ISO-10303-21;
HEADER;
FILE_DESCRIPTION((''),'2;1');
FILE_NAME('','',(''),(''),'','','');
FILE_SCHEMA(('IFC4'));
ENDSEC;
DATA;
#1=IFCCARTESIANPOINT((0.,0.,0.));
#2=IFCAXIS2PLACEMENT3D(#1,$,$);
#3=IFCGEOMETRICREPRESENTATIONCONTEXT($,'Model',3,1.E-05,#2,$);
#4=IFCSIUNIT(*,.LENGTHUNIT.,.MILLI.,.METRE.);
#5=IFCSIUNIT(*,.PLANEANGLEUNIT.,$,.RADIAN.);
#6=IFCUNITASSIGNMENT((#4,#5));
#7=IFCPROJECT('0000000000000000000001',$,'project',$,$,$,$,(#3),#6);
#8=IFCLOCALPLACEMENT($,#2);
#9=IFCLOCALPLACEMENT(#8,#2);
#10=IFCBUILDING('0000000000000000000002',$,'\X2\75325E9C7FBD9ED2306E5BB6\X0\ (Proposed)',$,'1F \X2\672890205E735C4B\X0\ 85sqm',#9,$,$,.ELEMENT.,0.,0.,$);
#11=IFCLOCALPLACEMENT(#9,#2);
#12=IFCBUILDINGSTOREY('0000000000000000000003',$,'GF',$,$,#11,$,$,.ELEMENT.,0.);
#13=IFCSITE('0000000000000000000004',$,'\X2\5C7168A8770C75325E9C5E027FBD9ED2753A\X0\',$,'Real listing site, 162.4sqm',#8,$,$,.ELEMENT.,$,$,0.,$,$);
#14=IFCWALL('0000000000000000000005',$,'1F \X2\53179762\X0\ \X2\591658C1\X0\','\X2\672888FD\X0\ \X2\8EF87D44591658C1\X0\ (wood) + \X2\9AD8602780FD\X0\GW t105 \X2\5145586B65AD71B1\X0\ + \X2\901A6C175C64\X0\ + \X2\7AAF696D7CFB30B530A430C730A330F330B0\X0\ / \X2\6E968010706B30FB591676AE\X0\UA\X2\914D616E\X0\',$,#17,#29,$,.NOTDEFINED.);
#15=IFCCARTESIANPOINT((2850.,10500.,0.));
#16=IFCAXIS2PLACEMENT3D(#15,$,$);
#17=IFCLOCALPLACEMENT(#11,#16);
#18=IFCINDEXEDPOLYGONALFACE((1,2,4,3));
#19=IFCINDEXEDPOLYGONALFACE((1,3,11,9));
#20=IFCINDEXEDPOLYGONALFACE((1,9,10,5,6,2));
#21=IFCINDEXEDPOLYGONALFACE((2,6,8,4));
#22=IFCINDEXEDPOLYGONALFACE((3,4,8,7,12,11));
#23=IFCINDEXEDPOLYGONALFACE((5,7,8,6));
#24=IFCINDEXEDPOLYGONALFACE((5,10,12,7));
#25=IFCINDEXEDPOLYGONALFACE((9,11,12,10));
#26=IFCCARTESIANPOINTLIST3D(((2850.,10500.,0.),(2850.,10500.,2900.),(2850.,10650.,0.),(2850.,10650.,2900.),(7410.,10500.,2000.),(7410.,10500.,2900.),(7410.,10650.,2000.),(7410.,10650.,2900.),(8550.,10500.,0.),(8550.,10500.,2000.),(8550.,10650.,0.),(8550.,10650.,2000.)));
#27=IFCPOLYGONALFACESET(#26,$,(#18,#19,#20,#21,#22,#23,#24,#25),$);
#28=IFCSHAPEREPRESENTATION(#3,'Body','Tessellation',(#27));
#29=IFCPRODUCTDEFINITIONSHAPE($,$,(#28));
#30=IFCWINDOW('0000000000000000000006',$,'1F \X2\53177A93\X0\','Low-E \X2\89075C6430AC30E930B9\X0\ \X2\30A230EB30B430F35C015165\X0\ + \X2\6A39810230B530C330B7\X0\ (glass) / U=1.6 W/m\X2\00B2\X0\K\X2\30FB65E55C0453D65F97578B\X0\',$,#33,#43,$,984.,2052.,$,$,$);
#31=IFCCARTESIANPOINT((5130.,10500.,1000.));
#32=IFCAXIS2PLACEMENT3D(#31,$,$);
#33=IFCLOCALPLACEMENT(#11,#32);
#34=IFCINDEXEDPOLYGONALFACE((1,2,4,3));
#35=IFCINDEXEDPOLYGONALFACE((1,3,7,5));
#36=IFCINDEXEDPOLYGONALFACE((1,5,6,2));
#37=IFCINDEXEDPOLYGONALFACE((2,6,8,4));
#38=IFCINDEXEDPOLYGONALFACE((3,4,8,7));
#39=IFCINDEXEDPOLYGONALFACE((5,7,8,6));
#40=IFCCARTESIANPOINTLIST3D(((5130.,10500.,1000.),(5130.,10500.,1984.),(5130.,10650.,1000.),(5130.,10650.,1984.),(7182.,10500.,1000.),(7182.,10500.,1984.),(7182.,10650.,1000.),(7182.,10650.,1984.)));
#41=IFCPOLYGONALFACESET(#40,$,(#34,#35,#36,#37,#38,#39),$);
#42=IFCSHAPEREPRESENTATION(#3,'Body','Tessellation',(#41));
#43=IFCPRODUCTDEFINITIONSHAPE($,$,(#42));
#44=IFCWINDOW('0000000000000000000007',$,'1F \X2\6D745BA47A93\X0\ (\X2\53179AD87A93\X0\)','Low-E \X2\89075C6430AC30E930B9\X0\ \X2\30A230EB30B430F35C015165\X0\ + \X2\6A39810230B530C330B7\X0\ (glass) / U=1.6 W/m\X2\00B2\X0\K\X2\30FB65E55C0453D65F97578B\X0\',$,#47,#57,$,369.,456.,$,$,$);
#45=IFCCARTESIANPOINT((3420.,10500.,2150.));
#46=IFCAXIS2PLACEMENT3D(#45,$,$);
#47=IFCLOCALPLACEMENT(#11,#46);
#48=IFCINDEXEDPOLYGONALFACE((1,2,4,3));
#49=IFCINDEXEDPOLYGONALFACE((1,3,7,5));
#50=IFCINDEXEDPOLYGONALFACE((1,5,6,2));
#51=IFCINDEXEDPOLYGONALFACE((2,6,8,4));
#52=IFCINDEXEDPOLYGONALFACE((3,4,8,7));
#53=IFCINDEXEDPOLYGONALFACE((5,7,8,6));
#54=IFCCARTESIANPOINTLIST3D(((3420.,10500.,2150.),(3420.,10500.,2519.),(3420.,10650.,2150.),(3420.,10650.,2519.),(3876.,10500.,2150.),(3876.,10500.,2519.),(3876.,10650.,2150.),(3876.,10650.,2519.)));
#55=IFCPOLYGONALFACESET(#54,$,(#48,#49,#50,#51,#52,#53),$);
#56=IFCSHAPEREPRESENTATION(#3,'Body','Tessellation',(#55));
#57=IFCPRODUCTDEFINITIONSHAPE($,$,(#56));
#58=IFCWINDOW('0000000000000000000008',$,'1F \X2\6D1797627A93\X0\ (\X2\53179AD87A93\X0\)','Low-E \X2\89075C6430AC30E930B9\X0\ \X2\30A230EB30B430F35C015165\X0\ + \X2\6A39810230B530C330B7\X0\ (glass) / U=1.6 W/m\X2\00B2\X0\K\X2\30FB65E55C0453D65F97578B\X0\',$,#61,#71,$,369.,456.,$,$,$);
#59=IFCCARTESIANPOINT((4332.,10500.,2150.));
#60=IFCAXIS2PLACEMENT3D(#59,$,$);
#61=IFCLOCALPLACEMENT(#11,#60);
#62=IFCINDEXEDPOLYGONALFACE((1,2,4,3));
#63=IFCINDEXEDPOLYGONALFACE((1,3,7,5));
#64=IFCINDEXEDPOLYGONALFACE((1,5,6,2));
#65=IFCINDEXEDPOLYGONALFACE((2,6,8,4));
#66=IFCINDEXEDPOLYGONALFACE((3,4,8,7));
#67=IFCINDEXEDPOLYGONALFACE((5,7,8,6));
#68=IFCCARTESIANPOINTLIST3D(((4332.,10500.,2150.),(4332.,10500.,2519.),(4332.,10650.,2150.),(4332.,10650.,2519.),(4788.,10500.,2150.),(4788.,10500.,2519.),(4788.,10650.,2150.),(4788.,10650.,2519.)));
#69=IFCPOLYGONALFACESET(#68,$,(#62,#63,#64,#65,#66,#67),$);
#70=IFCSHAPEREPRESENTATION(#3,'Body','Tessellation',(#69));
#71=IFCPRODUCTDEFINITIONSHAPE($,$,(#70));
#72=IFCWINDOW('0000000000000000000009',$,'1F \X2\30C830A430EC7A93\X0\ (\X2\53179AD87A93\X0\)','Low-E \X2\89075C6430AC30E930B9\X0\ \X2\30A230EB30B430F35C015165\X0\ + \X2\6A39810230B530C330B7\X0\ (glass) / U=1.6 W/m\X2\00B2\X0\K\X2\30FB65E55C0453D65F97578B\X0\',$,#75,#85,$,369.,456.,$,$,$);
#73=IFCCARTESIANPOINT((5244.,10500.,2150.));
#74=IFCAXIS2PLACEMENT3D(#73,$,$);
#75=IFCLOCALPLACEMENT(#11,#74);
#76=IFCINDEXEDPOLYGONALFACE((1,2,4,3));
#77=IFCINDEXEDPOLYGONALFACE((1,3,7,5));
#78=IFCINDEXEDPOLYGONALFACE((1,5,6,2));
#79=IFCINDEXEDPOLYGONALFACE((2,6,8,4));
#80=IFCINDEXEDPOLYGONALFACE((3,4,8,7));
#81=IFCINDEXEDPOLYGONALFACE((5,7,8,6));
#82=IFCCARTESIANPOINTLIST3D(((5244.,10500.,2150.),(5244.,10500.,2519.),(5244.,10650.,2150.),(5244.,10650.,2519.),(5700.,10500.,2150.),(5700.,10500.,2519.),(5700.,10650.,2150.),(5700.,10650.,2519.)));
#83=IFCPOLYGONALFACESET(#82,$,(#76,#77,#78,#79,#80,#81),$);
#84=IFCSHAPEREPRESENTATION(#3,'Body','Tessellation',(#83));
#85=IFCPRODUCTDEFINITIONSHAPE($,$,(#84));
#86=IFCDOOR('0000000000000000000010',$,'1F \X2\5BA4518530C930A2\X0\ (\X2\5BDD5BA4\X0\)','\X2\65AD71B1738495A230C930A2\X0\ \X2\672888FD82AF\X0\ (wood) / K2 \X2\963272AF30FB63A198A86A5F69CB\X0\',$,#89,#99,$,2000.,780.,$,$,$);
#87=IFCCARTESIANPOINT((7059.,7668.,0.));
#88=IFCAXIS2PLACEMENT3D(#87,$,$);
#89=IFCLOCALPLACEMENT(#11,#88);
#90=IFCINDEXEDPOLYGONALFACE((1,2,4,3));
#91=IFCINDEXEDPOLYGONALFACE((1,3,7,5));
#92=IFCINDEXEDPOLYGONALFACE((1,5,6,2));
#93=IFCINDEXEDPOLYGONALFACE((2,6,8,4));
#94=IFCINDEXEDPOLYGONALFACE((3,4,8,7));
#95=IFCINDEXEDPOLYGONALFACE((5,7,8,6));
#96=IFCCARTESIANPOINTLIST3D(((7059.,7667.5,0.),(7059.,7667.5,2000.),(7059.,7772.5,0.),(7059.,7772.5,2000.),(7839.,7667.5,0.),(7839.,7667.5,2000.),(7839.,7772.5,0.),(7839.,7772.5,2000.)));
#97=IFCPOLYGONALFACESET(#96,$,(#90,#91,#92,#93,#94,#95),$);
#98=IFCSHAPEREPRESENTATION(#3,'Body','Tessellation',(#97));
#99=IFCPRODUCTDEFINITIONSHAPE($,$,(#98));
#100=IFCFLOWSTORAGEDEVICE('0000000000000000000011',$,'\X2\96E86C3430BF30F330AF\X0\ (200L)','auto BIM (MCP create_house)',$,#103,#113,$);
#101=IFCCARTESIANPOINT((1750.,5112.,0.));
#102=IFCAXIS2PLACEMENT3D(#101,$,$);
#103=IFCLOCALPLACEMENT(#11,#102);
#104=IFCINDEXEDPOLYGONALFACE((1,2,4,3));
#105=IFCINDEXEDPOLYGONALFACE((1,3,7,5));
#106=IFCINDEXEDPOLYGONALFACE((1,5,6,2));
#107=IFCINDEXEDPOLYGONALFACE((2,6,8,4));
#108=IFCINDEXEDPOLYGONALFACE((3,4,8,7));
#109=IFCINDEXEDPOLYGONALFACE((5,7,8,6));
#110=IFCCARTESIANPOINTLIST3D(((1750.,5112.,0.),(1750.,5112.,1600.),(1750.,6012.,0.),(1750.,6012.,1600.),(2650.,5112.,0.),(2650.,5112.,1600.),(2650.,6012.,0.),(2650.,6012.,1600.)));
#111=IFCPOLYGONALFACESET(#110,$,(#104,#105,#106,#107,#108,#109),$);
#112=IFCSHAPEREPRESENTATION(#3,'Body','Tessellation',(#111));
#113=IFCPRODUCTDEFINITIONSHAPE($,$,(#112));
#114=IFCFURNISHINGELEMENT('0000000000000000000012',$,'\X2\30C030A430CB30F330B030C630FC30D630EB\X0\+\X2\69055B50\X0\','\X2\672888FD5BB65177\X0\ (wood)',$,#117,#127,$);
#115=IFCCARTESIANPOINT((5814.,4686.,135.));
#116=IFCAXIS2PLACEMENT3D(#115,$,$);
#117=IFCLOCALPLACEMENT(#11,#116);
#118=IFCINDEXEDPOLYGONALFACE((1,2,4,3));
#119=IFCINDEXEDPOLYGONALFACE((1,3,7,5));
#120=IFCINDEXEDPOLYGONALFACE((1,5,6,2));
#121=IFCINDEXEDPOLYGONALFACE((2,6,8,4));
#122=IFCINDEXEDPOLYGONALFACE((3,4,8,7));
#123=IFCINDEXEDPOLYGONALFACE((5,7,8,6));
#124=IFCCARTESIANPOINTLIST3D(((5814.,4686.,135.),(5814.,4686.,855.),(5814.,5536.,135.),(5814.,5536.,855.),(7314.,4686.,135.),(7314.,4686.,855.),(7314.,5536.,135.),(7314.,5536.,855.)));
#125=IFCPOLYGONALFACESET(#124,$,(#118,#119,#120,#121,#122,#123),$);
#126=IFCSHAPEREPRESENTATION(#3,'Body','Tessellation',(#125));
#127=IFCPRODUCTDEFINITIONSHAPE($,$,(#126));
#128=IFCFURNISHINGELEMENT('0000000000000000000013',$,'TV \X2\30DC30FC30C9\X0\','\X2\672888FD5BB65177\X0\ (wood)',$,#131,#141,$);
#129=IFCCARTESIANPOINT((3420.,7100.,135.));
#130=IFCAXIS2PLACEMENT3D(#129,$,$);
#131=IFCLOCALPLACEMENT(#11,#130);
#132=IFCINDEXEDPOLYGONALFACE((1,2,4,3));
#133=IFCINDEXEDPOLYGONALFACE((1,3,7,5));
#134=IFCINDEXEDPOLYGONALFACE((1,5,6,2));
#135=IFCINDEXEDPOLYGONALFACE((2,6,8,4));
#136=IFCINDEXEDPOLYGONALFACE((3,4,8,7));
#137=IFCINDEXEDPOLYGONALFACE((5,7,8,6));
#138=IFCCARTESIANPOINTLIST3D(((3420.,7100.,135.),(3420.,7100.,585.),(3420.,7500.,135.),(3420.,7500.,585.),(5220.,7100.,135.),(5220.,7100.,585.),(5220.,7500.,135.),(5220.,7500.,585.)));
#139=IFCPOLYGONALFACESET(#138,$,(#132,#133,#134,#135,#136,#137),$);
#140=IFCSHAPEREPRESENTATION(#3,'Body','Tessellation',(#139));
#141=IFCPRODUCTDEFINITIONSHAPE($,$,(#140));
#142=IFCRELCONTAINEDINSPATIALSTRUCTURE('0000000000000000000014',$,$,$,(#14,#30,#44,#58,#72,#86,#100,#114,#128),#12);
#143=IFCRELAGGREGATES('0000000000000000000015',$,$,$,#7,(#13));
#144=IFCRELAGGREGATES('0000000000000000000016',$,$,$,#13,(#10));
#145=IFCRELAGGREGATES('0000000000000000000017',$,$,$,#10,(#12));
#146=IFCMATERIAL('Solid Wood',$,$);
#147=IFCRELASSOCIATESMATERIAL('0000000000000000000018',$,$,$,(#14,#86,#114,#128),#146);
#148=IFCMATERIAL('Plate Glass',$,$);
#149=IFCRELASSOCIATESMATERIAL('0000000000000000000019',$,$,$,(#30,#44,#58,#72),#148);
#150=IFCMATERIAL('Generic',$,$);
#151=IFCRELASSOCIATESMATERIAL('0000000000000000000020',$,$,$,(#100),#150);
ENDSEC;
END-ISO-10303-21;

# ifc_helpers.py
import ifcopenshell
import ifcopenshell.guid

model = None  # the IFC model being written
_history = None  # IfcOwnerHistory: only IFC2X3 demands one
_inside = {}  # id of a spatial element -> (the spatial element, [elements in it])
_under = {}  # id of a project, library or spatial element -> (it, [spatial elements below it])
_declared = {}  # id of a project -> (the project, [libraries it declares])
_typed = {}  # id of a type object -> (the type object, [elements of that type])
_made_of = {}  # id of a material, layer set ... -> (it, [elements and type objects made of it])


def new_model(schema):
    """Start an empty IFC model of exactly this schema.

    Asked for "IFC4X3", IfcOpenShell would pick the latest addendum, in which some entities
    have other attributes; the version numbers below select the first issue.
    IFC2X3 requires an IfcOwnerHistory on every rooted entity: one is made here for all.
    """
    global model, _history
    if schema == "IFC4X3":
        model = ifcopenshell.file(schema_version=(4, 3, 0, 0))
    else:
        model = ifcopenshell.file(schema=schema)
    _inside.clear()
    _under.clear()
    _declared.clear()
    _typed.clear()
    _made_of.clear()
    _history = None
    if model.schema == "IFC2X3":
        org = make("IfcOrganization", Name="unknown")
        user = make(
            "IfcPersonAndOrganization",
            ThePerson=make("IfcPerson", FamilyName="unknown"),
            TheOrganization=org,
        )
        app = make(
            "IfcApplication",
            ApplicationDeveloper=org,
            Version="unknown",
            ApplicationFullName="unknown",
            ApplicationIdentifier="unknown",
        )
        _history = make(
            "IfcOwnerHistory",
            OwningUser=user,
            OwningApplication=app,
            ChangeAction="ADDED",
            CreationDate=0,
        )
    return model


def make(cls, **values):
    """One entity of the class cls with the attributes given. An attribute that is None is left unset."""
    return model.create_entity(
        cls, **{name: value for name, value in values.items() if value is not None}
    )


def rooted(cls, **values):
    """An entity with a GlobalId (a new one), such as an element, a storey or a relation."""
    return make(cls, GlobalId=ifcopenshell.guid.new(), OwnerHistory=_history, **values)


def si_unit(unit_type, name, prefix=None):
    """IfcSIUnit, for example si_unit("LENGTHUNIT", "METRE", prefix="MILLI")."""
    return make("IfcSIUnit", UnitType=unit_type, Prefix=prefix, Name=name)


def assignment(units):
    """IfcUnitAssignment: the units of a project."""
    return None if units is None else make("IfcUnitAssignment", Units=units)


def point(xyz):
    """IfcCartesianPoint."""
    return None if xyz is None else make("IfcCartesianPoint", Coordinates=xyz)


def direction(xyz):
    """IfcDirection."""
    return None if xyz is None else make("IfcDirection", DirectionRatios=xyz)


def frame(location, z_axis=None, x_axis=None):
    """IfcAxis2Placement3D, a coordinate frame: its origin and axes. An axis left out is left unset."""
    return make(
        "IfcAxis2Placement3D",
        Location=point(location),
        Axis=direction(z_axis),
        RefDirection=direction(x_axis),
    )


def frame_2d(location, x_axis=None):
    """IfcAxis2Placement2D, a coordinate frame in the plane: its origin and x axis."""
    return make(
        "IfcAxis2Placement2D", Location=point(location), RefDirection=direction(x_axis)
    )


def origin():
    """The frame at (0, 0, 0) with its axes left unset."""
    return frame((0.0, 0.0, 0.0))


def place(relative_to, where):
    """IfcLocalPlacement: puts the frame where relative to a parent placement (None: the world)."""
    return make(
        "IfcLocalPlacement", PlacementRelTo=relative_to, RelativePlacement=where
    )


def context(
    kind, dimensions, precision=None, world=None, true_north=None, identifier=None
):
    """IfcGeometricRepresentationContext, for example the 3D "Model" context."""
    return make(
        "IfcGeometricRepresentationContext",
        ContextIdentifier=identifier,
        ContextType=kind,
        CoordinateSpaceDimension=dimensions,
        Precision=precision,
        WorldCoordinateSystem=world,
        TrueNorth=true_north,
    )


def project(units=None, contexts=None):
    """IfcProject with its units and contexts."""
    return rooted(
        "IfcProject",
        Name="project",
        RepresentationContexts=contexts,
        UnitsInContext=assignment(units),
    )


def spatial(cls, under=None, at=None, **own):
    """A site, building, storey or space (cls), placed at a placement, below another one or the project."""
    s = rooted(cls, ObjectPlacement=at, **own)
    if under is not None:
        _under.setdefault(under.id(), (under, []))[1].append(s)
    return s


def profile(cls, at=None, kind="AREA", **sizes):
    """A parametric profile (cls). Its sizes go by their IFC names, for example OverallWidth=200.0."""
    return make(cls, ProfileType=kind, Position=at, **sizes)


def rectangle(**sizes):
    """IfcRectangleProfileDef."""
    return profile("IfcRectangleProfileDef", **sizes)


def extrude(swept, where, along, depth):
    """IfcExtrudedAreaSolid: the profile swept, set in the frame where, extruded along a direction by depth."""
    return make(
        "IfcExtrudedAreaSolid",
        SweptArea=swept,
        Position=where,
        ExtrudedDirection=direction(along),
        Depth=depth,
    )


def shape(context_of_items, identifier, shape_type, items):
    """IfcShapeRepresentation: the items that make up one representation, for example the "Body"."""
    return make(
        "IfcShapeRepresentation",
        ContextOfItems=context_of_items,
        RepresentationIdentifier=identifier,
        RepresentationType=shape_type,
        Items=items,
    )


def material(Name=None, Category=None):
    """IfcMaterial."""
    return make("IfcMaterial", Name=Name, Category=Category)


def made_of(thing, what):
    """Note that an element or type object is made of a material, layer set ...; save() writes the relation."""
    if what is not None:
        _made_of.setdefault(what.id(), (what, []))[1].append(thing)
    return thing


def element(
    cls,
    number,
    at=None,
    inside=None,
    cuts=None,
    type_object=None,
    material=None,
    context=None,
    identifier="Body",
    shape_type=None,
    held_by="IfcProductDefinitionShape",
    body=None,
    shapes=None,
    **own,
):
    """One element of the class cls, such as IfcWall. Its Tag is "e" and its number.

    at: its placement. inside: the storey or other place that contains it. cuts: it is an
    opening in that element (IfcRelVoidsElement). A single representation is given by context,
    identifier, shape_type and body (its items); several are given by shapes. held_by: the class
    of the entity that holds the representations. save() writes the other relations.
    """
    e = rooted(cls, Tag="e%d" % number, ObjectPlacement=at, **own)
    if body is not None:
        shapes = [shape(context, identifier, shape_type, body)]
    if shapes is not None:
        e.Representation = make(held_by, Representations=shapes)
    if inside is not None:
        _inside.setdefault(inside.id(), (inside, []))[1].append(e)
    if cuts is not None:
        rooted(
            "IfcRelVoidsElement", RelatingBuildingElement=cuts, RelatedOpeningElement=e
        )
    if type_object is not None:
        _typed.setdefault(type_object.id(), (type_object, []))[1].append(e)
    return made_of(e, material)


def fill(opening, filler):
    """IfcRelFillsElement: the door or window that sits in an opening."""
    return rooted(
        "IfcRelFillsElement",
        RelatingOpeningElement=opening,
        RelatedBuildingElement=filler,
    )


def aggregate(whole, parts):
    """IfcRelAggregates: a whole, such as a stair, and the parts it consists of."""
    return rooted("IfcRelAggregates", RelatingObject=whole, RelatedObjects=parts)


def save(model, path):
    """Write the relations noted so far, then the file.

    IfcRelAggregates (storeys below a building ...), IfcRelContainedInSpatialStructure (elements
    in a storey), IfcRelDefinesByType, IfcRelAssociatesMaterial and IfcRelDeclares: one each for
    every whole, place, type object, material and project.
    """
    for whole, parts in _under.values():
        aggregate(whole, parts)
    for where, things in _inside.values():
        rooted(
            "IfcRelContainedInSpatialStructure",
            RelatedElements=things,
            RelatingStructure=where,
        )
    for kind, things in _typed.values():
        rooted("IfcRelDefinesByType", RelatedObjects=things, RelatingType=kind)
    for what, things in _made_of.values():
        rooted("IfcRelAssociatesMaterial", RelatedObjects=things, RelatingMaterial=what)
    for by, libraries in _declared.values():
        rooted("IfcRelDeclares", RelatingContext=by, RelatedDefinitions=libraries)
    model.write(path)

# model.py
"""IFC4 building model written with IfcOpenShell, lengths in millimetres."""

from ifc_helpers import new_model, si_unit, frame, frame_2d, origin, place, context, project, spatial, rectangle, extrude, material, element, fill, save


model = new_model("IFC4")

# Units and contexts
model_context = context("Model", 3, precision=1e-05, world=origin())
ifc_project = project(units=[si_unit("LENGTHUNIT", "METRE", prefix="MILLI"), si_unit("PLANEANGLEUNIT", "RADIAN")], contexts=[model_context])

# Site, building, storey
site_placement = place(None, origin())
site = spatial("IfcSite", under=ifc_project, at=site_placement, Name="山梨県甲府市羽黒町", ObjectType="Real listing site, 162.4sqm", CompositionType="ELEMENT", RefElevation=0.0)
building_placement = place(site_placement, origin())
building = spatial("IfcBuilding", under=site, at=building_placement, Name="甲府羽黒の家 (Proposed)", ObjectType="1F 木造平屋 85sqm", CompositionType="ELEMENT", ElevationOfRefHeight=0.0, ElevationOfTerrain=0.0)
storey_placement = place(building_placement, origin())
storey = spatial("IfcBuildingStorey", under=building, at=storey_placement, Name="GF", CompositionType="ELEMENT", Elevation=0.0)

# Wall, openings, windows
ifc_material_1 = material(Name="Solid Wood")
wall_1_placement = place(storey_placement, frame((2850.0, 10500.0, 0.0)))
wall_1 = element("IfcWall", 1, at=wall_1_placement, inside=storey, material=ifc_material_1, Name="1F 北面 外壁", Description="木製 軸組外壁 (wood) + 高性能GW t105 充填断熱 + 通気層 + 窯業系サイディング / 準耐火・外皮UA配慮", PredefinedType="NOTDEFINED", context=model_context, shape_type="SweptSolid", body=[
    extrude(rectangle(XDim=5700.0, YDim=150.0, at=frame_2d((2850.0, 75.0))), frame((2850.0, 10500.0, 0.0)), (0.0, 0.0, 1.0), 2900.0),
])
opening_1_placement = place(storey_placement, frame((5130.0, 10500.0, 1000.0)))
opening_1 = element("IfcOpeningElement", 2, at=opening_1_placement, cuts=wall_1, PredefinedType="NOTDEFINED", context=model_context, shape_type="SweptSolid", body=[
    extrude(rectangle(XDim=2052.0, YDim=150.0, at=frame_2d((1026.0, 75.0))), frame((5130.0, 10500.0, 1000.0)), (0.0, 0.0, 1.0), 984.0),
])
opening_2_placement = place(storey_placement, frame((3420.0, 10500.0, 2150.0)))
opening_2 = element("IfcOpeningElement", 3, at=opening_2_placement, cuts=wall_1, PredefinedType="NOTDEFINED", context=model_context, shape_type="SweptSolid", body=[
    extrude(rectangle(XDim=456.0, YDim=150.0, at=frame_2d((228.0, 75.0))), frame((3420.0, 10500.0, 2150.0)), (0.0, 0.0, 1.0), 369.0),
])
opening_3_placement = place(storey_placement, frame((4332.0, 10500.0, 2150.0)))
opening_3 = element("IfcOpeningElement", 4, at=opening_3_placement, cuts=wall_1, PredefinedType="NOTDEFINED", context=model_context, shape_type="SweptSolid", body=[
    extrude(rectangle(XDim=456.0, YDim=150.0, at=frame_2d((228.0, 75.0))), frame((4332.0, 10500.0, 2150.0)), (0.0, 0.0, 1.0), 369.0),
])
opening_4_placement = place(storey_placement, frame((5244.0, 10500.0, 2150.0)))
opening_4 = element("IfcOpeningElement", 5, at=opening_4_placement, cuts=wall_1, PredefinedType="NOTDEFINED", context=model_context, shape_type="SweptSolid", body=[
    extrude(rectangle(XDim=456.0, YDim=150.0, at=frame_2d((228.0, 75.0))), frame((5244.0, 10500.0, 2150.0)), (0.0, 0.0, 1.0), 369.0),
])
ifc_material_2 = material(Name="Plate Glass")
window_1_placement = place(storey_placement, frame((5130.0, 10500.0, 1000.0)))
window_1 = element("IfcWindow", 6, at=window_1_placement, inside=storey, material=ifc_material_2, Name="1F 北窓", Description="Low-E 複層ガラス アルゴン封入 + 樹脂サッシ (glass) / U=1.6 W/m²K・日射取得型", OverallHeight=984.0, OverallWidth=2052.0, context=model_context, shape_type="SweptSolid", body=[
    extrude(rectangle(XDim=2052.0, YDim=150.0, at=frame_2d((1026.0, 75.0))), frame((5130.0, 10500.0, 1000.0)), (0.0, 0.0, 1.0), 984.0),
])
fill(opening_1, window_1)
window_2_placement = place(storey_placement, frame((3420.0, 10500.0, 2150.0)))
window_2 = element("IfcWindow", 7, at=window_2_placement, inside=storey, material=ifc_material_2, Name="1F 浴室窓 (北高窓)", Description="Low-E 複層ガラス アルゴン封入 + 樹脂サッシ (glass) / U=1.6 W/m²K・日射取得型", OverallHeight=369.0, OverallWidth=456.0, context=model_context, shape_type="SweptSolid", body=[
    extrude(rectangle(XDim=456.0, YDim=150.0, at=frame_2d((228.0, 75.0))), frame((3420.0, 10500.0, 2150.0)), (0.0, 0.0, 1.0), 369.0),
])
fill(opening_2, window_2)
window_3_placement = place(storey_placement, frame((4332.0, 10500.0, 2150.0)))
window_3 = element("IfcWindow", 8, at=window_3_placement, inside=storey, material=ifc_material_2, Name="1F 洗面窓 (北高窓)", Description="Low-E 複層ガラス アルゴン封入 + 樹脂サッシ (glass) / U=1.6 W/m²K・日射取得型", OverallHeight=369.0, OverallWidth=456.0, context=model_context, shape_type="SweptSolid", body=[
    extrude(rectangle(XDim=456.0, YDim=150.0, at=frame_2d((228.0, 75.0))), frame((4332.0, 10500.0, 2150.0)), (0.0, 0.0, 1.0), 369.0),
])
fill(opening_3, window_3)
window_4_placement = place(storey_placement, frame((5244.0, 10500.0, 2150.0)))
window_4 = element("IfcWindow", 9, at=window_4_placement, inside=storey, material=ifc_material_2, Name="1F トイレ窓 (北高窓)", Description="Low-E 複層ガラス アルゴン封入 + 樹脂サッシ (glass) / U=1.6 W/m²K・日射取得型", OverallHeight=369.0, OverallWidth=456.0, context=model_context, shape_type="SweptSolid", body=[
    extrude(rectangle(XDim=456.0, YDim=150.0, at=frame_2d((228.0, 75.0))), frame((5244.0, 10500.0, 2150.0)), (0.0, 0.0, 1.0), 369.0),
])
fill(opening_4, window_4)

# Door
door_1_placement = place(storey_placement, frame((7059.0, 7668.0, 0.0)))
element("IfcDoor", 10, at=door_1_placement, inside=storey, material=ifc_material_1, Name="1F 室内ドア (寝室)", Description="断熱玄関ドア 木製芯 (wood) / K2 防犯・採風機構", OverallHeight=2000.0, OverallWidth=780.0, context=model_context, shape_type="SweptSolid", body=[
    extrude(rectangle(XDim=780.0, YDim=105.0, at=frame_2d((390.0, 52.0))), frame((7059.0, 7668.0, 0.0)), (0.0, 0.0, 1.0), 2000.0),
])

# Flow storage device
ifc_material_3 = material(Name="Generic")
flow_storage_device_placement = place(storey_placement, frame((1750.0, 5112.0, 0.0)))
element("IfcFlowStorageDevice", 11, at=flow_storage_device_placement, inside=storey, material=ifc_material_3, Name="雨水タンク (200L)", Description="auto BIM (MCP create_house)", context=model_context, shape_type="SweptSolid", body=[
    extrude(rectangle(XDim=900.0, YDim=900.0, at=frame_2d((450.0, 450.0))), frame((1750.0, 5112.0, 0.0)), (0.0, 0.0, 1.0), 1600.0),
])

# Furnishing elements
furnishing_1_placement = place(storey_placement, frame((5814.0, 4686.0, 135.0)))
element("IfcFurnishingElement", 12, at=furnishing_1_placement, inside=storey, material=ifc_material_1, Name="ダイニングテーブル+椅子", Description="木製家具 (wood)", context=model_context, shape_type="SweptSolid", body=[
    extrude(rectangle(XDim=1500.0, YDim=850.0, at=frame_2d((750.0, 425.0))), frame((5814.0, 4686.0, 135.0)), (0.0, 0.0, 1.0), 720.0),
])
furnishing_2_placement = place(storey_placement, frame((3420.0, 7100.0, 135.0)))
element("IfcFurnishingElement", 13, at=furnishing_2_placement, inside=storey, material=ifc_material_1, Name="TV ボード", Description="木製家具 (wood)", context=model_context, shape_type="SweptSolid", body=[
    extrude(rectangle(XDim=1800.0, YDim=400.0, at=frame_2d((900.0, 200.0))), frame((3420.0, 7100.0, 135.0)), (0.0, 0.0, 1.0), 450.0),
])

save(model, "model.ifc")
